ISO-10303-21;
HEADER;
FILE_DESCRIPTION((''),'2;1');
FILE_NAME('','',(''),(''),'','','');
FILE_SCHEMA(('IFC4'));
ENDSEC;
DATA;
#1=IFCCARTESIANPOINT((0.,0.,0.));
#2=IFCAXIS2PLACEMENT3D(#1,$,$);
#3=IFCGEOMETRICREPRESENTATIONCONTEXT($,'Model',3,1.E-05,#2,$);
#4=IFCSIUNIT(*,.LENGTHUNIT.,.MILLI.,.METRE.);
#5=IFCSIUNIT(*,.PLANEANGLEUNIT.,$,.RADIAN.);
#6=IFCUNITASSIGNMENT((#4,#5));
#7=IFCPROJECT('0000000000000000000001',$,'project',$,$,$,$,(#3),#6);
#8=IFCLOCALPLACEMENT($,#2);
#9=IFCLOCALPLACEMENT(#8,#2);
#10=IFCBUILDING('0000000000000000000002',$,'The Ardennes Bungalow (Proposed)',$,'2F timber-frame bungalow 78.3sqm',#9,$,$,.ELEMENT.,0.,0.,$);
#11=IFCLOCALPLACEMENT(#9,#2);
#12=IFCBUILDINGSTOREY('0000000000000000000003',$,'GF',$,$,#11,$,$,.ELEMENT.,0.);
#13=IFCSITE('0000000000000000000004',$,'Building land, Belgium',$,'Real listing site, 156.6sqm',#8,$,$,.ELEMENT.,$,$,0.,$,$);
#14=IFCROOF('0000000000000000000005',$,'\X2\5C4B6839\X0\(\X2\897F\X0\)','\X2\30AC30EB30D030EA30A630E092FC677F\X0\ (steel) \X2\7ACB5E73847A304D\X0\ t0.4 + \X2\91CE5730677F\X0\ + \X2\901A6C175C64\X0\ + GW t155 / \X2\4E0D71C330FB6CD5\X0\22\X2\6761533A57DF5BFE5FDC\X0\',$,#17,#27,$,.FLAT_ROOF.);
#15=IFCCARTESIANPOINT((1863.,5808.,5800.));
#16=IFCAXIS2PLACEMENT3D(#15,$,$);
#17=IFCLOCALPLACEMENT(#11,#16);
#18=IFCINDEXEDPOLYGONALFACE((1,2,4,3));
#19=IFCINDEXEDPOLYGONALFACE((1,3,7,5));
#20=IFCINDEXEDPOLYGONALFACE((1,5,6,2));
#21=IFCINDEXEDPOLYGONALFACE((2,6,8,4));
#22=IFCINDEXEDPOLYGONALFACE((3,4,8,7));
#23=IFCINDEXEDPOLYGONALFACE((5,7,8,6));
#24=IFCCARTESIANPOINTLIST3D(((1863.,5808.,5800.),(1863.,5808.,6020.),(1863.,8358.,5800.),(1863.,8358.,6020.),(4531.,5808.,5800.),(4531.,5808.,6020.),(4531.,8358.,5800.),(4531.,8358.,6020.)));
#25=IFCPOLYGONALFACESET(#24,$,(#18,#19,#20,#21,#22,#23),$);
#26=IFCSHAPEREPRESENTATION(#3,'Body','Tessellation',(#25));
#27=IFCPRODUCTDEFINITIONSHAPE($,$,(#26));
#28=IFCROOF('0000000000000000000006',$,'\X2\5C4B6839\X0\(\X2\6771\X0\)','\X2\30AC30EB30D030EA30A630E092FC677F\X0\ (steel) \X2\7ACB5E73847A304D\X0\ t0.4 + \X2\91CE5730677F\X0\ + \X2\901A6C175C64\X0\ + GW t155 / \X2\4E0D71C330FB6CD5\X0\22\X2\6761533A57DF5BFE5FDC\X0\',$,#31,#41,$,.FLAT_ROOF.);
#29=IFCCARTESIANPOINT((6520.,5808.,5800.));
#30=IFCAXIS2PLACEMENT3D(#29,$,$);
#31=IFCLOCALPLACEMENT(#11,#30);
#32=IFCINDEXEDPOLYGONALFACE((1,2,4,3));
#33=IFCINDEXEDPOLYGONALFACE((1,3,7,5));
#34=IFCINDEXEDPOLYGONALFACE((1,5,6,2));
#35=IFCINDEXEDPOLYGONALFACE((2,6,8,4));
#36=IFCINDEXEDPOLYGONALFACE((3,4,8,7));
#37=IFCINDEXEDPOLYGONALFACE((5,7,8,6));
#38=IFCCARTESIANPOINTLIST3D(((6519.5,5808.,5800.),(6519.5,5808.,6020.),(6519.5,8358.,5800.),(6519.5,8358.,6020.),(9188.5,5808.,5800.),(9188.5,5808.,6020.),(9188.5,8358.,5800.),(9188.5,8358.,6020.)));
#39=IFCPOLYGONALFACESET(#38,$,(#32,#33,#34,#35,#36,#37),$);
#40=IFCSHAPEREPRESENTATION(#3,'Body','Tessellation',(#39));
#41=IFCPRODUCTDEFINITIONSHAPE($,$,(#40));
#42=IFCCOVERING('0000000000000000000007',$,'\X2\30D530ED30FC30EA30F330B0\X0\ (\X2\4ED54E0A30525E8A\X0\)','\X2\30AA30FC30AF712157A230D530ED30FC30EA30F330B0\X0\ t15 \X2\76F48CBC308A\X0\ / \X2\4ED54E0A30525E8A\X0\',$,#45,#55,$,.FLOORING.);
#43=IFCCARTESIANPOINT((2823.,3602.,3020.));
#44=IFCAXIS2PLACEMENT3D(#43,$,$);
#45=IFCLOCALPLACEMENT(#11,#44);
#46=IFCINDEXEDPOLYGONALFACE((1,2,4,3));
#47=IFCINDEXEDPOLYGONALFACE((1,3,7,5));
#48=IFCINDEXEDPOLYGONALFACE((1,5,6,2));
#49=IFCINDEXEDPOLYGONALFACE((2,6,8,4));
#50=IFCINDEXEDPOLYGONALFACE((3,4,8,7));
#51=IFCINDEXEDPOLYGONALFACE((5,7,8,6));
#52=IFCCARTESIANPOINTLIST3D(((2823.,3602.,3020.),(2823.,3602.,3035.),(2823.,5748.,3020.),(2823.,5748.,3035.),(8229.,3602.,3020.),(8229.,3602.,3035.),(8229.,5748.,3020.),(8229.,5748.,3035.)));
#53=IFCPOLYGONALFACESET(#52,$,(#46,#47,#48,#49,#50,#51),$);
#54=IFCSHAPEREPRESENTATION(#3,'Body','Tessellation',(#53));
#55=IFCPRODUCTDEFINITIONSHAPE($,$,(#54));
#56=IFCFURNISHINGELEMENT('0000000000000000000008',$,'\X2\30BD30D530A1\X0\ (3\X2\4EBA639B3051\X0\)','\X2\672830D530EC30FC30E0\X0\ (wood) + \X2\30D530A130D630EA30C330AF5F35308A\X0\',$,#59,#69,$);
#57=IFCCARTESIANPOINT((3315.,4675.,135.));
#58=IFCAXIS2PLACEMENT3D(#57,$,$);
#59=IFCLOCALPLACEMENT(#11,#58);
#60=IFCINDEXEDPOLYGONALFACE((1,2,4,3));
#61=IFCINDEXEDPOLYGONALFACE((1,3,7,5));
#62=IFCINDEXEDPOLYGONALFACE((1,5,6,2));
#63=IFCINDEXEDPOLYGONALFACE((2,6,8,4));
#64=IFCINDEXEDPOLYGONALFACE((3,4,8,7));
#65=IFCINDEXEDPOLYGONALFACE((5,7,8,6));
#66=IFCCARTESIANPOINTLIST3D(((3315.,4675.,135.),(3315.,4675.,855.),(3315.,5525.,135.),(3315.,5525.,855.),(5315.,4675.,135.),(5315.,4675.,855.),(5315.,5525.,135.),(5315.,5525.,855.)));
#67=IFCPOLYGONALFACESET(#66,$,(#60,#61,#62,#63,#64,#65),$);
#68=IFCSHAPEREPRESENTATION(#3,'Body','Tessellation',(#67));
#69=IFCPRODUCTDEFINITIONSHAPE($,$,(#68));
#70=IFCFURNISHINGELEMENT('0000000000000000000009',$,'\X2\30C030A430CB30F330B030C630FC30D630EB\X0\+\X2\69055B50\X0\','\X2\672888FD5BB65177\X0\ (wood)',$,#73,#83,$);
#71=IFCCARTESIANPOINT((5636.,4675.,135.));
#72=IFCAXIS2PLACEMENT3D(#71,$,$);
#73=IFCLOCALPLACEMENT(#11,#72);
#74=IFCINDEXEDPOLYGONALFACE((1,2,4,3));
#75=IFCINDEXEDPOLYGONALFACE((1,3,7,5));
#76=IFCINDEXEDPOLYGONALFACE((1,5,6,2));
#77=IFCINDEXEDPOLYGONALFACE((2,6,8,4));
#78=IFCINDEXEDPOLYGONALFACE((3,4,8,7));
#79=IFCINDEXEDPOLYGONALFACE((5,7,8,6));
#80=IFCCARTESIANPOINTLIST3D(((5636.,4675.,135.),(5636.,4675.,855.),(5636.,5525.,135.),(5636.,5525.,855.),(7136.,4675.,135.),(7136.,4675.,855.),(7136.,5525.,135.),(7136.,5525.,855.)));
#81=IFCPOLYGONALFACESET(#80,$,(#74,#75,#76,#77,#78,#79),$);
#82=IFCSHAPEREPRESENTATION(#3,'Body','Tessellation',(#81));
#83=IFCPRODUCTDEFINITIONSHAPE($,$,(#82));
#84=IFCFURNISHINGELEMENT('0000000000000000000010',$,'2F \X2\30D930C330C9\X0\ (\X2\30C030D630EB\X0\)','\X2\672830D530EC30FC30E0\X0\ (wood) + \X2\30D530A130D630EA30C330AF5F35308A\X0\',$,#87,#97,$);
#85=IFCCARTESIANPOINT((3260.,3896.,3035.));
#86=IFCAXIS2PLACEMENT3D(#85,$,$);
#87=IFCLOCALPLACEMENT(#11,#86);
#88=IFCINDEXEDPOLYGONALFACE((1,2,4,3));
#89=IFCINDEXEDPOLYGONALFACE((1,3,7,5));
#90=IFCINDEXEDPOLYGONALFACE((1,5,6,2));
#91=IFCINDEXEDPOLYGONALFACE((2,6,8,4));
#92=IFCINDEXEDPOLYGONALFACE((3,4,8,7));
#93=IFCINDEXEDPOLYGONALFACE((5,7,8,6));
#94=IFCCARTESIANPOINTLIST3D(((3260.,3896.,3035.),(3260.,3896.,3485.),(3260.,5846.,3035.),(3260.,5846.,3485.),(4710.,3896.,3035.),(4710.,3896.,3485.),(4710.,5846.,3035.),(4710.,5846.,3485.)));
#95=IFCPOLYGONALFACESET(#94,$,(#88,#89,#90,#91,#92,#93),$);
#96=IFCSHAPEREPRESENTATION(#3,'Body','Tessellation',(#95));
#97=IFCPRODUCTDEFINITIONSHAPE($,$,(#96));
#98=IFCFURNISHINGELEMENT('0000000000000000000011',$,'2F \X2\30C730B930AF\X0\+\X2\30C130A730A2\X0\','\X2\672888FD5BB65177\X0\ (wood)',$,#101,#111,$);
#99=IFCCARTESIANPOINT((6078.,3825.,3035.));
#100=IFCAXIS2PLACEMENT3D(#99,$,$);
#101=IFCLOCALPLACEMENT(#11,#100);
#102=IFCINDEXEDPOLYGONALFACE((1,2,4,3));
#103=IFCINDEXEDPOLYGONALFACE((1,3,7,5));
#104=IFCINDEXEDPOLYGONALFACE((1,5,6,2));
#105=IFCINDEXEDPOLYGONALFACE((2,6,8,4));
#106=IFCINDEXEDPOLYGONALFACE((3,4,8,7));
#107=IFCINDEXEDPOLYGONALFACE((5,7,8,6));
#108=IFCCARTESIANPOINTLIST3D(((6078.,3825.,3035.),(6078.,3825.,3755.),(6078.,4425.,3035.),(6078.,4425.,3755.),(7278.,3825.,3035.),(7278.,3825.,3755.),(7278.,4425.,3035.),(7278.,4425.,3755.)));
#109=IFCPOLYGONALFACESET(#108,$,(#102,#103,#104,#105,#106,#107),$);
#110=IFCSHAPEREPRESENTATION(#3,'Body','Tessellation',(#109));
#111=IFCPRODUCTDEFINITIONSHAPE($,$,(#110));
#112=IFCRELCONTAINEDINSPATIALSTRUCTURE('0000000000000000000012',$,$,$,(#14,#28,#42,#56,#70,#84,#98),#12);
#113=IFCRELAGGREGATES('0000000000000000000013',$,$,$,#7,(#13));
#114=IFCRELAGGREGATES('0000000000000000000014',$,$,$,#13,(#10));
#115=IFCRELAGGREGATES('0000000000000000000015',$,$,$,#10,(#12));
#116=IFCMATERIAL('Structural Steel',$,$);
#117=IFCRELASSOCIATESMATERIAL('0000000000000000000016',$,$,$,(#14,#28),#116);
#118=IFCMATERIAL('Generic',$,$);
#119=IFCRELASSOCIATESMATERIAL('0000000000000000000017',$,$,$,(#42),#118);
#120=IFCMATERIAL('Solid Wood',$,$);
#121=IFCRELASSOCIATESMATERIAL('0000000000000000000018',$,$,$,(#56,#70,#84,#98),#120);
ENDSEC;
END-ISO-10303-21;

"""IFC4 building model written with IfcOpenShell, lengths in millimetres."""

from ifc_helpers import new_model, si_unit, frame, frame_2d, origin, place, context, project, spatial, rectangle, extrude, material, element, save


model = new_model("IFC4")

# Units and contexts
model_context = context("Model", 3, precision=1e-05, world=origin())
ifc_project = project(units=[si_unit("LENGTHUNIT", "METRE", prefix="MILLI"), si_unit("PLANEANGLEUNIT", "RADIAN")], contexts=[model_context])

# Site, building, storey
site_placement = place(None, origin())
site = spatial("IfcSite", under=ifc_project, at=site_placement, Name="Building land, Belgium", ObjectType="Real listing site, 156.6sqm", CompositionType="ELEMENT", RefElevation=0.0)
building_placement = place(site_placement, origin())
building = spatial("IfcBuilding", under=site, at=building_placement, Name="The Ardennes Bungalow (Proposed)", ObjectType="2F timber-frame bungalow 78.3sqm", CompositionType="ELEMENT", ElevationOfRefHeight=0.0, ElevationOfTerrain=0.0)
storey_placement = place(building_placement, origin())
storey = spatial("IfcBuildingStorey", under=building, at=storey_placement, Name="GF", CompositionType="ELEMENT", Elevation=0.0)

# Shared definitions
ifc_material_1 = material(Name="Solid Wood")

# Roofs
ifc_material_2 = material(Name="Structural Steel")
roof_1_placement = place(storey_placement, frame((1863.0, 5808.0, 5800.0)))
element("IfcRoof", 1, at=roof_1_placement, inside=storey, material=ifc_material_2, Name="屋根(西)", Description="ガルバリウム鋼板 (steel) 立平葺き t0.4 + 野地板 + 通気層 + GW t155 / 不燃・法22条区域対応", PredefinedType="FLAT_ROOF", context=model_context, shape_type="SweptSolid", body=[
    extrude(rectangle(XDim=2668.0, YDim=2550.0, at=frame_2d((1334.0, 1275.0))), frame((1863.0, 5808.0, 5800.0)), (0.0, 0.0, 1.0), 220.0),
])
roof_2_placement = place(storey_placement, frame((6520.0, 5808.0, 5800.0)))
element("IfcRoof", 2, at=roof_2_placement, inside=storey, material=ifc_material_2, Name="屋根(東)", Description="ガルバリウム鋼板 (steel) 立平葺き t0.4 + 野地板 + 通気層 + GW t155 / 不燃・法22条区域対応", PredefinedType="FLAT_ROOF", context=model_context, shape_type="SweptSolid", body=[
    extrude(rectangle(XDim=2669.0, YDim=2550.0, at=frame_2d((1334.0, 1275.0))), frame((6520.0, 5808.0, 5800.0)), (0.0, 0.0, 1.0), 220.0),
])

# Covering
ifc_material_3 = material(Name="Generic")
covering_placement = place(storey_placement, frame((2823.0, 3602.0, 3020.0)))
element("IfcCovering", 3, at=covering_placement, inside=storey, material=ifc_material_3, Name="フローリング (仕上げ床)", Description="オーク無垢フローリング t15 直貼り / 仕上げ床", PredefinedType="FLOORING", context=model_context, shape_type="SweptSolid", body=[
    extrude(rectangle(XDim=5406.0, YDim=2146.0, at=frame_2d((2703.0, 1073.0))), frame((2823.0, 3602.0, 3020.0)), (0.0, 0.0, 1.0), 15.0),
])

# Furnishing elements
furnishing_1_placement = place(storey_placement, frame((3315.0, 4675.0, 135.0)))
element("IfcFurnishingElement", 4, at=furnishing_1_placement, inside=storey, material=ifc_material_1, Name="ソファ (3人掛け)", Description="木フレーム (wood) + ファブリック張り", context=model_context, shape_type="SweptSolid", body=[
    extrude(rectangle(XDim=2000.0, YDim=850.0, at=frame_2d((1000.0, 425.0))), frame((3315.0, 4675.0, 135.0)), (0.0, 0.0, 1.0), 720.0),
])
furnishing_2_placement = place(storey_placement, frame((5636.0, 4675.0, 135.0)))
element("IfcFurnishingElement", 5, at=furnishing_2_placement, inside=storey, material=ifc_material_1, Name="ダイニングテーブル+椅子", Description="木製家具 (wood)", context=model_context, shape_type="SweptSolid", body=[
    extrude(rectangle(XDim=1500.0, YDim=850.0, at=frame_2d((750.0, 425.0))), frame((5636.0, 4675.0, 135.0)), (0.0, 0.0, 1.0), 720.0),
])
furnishing_3_placement = place(storey_placement, frame((3260.0, 3896.0, 3035.0)))
element("IfcFurnishingElement", 6, at=furnishing_3_placement, inside=storey, material=ifc_material_1, Name="2F ベッド (ダブル)", Description="木フレーム (wood) + ファブリック張り", context=model_context, shape_type="SweptSolid", body=[
    extrude(rectangle(XDim=1450.0, YDim=1950.0, at=frame_2d((725.0, 975.0))), frame((3260.0, 3896.0, 3035.0)), (0.0, 0.0, 1.0), 450.0),
])
furnishing_4_placement = place(storey_placement, frame((6078.0, 3825.0, 3035.0)))
element("IfcFurnishingElement", 7, at=furnishing_4_placement, inside=storey, material=ifc_material_1, Name="2F デスク+チェア", Description="木製家具 (wood)", context=model_context, shape_type="SweptSolid", body=[
    extrude(rectangle(XDim=1200.0, YDim=600.0, at=frame_2d((600.0, 300.0))), frame((6078.0, 3825.0, 3035.0)), (0.0, 0.0, 1.0), 720.0),
])

save(model, "model.ifc")
